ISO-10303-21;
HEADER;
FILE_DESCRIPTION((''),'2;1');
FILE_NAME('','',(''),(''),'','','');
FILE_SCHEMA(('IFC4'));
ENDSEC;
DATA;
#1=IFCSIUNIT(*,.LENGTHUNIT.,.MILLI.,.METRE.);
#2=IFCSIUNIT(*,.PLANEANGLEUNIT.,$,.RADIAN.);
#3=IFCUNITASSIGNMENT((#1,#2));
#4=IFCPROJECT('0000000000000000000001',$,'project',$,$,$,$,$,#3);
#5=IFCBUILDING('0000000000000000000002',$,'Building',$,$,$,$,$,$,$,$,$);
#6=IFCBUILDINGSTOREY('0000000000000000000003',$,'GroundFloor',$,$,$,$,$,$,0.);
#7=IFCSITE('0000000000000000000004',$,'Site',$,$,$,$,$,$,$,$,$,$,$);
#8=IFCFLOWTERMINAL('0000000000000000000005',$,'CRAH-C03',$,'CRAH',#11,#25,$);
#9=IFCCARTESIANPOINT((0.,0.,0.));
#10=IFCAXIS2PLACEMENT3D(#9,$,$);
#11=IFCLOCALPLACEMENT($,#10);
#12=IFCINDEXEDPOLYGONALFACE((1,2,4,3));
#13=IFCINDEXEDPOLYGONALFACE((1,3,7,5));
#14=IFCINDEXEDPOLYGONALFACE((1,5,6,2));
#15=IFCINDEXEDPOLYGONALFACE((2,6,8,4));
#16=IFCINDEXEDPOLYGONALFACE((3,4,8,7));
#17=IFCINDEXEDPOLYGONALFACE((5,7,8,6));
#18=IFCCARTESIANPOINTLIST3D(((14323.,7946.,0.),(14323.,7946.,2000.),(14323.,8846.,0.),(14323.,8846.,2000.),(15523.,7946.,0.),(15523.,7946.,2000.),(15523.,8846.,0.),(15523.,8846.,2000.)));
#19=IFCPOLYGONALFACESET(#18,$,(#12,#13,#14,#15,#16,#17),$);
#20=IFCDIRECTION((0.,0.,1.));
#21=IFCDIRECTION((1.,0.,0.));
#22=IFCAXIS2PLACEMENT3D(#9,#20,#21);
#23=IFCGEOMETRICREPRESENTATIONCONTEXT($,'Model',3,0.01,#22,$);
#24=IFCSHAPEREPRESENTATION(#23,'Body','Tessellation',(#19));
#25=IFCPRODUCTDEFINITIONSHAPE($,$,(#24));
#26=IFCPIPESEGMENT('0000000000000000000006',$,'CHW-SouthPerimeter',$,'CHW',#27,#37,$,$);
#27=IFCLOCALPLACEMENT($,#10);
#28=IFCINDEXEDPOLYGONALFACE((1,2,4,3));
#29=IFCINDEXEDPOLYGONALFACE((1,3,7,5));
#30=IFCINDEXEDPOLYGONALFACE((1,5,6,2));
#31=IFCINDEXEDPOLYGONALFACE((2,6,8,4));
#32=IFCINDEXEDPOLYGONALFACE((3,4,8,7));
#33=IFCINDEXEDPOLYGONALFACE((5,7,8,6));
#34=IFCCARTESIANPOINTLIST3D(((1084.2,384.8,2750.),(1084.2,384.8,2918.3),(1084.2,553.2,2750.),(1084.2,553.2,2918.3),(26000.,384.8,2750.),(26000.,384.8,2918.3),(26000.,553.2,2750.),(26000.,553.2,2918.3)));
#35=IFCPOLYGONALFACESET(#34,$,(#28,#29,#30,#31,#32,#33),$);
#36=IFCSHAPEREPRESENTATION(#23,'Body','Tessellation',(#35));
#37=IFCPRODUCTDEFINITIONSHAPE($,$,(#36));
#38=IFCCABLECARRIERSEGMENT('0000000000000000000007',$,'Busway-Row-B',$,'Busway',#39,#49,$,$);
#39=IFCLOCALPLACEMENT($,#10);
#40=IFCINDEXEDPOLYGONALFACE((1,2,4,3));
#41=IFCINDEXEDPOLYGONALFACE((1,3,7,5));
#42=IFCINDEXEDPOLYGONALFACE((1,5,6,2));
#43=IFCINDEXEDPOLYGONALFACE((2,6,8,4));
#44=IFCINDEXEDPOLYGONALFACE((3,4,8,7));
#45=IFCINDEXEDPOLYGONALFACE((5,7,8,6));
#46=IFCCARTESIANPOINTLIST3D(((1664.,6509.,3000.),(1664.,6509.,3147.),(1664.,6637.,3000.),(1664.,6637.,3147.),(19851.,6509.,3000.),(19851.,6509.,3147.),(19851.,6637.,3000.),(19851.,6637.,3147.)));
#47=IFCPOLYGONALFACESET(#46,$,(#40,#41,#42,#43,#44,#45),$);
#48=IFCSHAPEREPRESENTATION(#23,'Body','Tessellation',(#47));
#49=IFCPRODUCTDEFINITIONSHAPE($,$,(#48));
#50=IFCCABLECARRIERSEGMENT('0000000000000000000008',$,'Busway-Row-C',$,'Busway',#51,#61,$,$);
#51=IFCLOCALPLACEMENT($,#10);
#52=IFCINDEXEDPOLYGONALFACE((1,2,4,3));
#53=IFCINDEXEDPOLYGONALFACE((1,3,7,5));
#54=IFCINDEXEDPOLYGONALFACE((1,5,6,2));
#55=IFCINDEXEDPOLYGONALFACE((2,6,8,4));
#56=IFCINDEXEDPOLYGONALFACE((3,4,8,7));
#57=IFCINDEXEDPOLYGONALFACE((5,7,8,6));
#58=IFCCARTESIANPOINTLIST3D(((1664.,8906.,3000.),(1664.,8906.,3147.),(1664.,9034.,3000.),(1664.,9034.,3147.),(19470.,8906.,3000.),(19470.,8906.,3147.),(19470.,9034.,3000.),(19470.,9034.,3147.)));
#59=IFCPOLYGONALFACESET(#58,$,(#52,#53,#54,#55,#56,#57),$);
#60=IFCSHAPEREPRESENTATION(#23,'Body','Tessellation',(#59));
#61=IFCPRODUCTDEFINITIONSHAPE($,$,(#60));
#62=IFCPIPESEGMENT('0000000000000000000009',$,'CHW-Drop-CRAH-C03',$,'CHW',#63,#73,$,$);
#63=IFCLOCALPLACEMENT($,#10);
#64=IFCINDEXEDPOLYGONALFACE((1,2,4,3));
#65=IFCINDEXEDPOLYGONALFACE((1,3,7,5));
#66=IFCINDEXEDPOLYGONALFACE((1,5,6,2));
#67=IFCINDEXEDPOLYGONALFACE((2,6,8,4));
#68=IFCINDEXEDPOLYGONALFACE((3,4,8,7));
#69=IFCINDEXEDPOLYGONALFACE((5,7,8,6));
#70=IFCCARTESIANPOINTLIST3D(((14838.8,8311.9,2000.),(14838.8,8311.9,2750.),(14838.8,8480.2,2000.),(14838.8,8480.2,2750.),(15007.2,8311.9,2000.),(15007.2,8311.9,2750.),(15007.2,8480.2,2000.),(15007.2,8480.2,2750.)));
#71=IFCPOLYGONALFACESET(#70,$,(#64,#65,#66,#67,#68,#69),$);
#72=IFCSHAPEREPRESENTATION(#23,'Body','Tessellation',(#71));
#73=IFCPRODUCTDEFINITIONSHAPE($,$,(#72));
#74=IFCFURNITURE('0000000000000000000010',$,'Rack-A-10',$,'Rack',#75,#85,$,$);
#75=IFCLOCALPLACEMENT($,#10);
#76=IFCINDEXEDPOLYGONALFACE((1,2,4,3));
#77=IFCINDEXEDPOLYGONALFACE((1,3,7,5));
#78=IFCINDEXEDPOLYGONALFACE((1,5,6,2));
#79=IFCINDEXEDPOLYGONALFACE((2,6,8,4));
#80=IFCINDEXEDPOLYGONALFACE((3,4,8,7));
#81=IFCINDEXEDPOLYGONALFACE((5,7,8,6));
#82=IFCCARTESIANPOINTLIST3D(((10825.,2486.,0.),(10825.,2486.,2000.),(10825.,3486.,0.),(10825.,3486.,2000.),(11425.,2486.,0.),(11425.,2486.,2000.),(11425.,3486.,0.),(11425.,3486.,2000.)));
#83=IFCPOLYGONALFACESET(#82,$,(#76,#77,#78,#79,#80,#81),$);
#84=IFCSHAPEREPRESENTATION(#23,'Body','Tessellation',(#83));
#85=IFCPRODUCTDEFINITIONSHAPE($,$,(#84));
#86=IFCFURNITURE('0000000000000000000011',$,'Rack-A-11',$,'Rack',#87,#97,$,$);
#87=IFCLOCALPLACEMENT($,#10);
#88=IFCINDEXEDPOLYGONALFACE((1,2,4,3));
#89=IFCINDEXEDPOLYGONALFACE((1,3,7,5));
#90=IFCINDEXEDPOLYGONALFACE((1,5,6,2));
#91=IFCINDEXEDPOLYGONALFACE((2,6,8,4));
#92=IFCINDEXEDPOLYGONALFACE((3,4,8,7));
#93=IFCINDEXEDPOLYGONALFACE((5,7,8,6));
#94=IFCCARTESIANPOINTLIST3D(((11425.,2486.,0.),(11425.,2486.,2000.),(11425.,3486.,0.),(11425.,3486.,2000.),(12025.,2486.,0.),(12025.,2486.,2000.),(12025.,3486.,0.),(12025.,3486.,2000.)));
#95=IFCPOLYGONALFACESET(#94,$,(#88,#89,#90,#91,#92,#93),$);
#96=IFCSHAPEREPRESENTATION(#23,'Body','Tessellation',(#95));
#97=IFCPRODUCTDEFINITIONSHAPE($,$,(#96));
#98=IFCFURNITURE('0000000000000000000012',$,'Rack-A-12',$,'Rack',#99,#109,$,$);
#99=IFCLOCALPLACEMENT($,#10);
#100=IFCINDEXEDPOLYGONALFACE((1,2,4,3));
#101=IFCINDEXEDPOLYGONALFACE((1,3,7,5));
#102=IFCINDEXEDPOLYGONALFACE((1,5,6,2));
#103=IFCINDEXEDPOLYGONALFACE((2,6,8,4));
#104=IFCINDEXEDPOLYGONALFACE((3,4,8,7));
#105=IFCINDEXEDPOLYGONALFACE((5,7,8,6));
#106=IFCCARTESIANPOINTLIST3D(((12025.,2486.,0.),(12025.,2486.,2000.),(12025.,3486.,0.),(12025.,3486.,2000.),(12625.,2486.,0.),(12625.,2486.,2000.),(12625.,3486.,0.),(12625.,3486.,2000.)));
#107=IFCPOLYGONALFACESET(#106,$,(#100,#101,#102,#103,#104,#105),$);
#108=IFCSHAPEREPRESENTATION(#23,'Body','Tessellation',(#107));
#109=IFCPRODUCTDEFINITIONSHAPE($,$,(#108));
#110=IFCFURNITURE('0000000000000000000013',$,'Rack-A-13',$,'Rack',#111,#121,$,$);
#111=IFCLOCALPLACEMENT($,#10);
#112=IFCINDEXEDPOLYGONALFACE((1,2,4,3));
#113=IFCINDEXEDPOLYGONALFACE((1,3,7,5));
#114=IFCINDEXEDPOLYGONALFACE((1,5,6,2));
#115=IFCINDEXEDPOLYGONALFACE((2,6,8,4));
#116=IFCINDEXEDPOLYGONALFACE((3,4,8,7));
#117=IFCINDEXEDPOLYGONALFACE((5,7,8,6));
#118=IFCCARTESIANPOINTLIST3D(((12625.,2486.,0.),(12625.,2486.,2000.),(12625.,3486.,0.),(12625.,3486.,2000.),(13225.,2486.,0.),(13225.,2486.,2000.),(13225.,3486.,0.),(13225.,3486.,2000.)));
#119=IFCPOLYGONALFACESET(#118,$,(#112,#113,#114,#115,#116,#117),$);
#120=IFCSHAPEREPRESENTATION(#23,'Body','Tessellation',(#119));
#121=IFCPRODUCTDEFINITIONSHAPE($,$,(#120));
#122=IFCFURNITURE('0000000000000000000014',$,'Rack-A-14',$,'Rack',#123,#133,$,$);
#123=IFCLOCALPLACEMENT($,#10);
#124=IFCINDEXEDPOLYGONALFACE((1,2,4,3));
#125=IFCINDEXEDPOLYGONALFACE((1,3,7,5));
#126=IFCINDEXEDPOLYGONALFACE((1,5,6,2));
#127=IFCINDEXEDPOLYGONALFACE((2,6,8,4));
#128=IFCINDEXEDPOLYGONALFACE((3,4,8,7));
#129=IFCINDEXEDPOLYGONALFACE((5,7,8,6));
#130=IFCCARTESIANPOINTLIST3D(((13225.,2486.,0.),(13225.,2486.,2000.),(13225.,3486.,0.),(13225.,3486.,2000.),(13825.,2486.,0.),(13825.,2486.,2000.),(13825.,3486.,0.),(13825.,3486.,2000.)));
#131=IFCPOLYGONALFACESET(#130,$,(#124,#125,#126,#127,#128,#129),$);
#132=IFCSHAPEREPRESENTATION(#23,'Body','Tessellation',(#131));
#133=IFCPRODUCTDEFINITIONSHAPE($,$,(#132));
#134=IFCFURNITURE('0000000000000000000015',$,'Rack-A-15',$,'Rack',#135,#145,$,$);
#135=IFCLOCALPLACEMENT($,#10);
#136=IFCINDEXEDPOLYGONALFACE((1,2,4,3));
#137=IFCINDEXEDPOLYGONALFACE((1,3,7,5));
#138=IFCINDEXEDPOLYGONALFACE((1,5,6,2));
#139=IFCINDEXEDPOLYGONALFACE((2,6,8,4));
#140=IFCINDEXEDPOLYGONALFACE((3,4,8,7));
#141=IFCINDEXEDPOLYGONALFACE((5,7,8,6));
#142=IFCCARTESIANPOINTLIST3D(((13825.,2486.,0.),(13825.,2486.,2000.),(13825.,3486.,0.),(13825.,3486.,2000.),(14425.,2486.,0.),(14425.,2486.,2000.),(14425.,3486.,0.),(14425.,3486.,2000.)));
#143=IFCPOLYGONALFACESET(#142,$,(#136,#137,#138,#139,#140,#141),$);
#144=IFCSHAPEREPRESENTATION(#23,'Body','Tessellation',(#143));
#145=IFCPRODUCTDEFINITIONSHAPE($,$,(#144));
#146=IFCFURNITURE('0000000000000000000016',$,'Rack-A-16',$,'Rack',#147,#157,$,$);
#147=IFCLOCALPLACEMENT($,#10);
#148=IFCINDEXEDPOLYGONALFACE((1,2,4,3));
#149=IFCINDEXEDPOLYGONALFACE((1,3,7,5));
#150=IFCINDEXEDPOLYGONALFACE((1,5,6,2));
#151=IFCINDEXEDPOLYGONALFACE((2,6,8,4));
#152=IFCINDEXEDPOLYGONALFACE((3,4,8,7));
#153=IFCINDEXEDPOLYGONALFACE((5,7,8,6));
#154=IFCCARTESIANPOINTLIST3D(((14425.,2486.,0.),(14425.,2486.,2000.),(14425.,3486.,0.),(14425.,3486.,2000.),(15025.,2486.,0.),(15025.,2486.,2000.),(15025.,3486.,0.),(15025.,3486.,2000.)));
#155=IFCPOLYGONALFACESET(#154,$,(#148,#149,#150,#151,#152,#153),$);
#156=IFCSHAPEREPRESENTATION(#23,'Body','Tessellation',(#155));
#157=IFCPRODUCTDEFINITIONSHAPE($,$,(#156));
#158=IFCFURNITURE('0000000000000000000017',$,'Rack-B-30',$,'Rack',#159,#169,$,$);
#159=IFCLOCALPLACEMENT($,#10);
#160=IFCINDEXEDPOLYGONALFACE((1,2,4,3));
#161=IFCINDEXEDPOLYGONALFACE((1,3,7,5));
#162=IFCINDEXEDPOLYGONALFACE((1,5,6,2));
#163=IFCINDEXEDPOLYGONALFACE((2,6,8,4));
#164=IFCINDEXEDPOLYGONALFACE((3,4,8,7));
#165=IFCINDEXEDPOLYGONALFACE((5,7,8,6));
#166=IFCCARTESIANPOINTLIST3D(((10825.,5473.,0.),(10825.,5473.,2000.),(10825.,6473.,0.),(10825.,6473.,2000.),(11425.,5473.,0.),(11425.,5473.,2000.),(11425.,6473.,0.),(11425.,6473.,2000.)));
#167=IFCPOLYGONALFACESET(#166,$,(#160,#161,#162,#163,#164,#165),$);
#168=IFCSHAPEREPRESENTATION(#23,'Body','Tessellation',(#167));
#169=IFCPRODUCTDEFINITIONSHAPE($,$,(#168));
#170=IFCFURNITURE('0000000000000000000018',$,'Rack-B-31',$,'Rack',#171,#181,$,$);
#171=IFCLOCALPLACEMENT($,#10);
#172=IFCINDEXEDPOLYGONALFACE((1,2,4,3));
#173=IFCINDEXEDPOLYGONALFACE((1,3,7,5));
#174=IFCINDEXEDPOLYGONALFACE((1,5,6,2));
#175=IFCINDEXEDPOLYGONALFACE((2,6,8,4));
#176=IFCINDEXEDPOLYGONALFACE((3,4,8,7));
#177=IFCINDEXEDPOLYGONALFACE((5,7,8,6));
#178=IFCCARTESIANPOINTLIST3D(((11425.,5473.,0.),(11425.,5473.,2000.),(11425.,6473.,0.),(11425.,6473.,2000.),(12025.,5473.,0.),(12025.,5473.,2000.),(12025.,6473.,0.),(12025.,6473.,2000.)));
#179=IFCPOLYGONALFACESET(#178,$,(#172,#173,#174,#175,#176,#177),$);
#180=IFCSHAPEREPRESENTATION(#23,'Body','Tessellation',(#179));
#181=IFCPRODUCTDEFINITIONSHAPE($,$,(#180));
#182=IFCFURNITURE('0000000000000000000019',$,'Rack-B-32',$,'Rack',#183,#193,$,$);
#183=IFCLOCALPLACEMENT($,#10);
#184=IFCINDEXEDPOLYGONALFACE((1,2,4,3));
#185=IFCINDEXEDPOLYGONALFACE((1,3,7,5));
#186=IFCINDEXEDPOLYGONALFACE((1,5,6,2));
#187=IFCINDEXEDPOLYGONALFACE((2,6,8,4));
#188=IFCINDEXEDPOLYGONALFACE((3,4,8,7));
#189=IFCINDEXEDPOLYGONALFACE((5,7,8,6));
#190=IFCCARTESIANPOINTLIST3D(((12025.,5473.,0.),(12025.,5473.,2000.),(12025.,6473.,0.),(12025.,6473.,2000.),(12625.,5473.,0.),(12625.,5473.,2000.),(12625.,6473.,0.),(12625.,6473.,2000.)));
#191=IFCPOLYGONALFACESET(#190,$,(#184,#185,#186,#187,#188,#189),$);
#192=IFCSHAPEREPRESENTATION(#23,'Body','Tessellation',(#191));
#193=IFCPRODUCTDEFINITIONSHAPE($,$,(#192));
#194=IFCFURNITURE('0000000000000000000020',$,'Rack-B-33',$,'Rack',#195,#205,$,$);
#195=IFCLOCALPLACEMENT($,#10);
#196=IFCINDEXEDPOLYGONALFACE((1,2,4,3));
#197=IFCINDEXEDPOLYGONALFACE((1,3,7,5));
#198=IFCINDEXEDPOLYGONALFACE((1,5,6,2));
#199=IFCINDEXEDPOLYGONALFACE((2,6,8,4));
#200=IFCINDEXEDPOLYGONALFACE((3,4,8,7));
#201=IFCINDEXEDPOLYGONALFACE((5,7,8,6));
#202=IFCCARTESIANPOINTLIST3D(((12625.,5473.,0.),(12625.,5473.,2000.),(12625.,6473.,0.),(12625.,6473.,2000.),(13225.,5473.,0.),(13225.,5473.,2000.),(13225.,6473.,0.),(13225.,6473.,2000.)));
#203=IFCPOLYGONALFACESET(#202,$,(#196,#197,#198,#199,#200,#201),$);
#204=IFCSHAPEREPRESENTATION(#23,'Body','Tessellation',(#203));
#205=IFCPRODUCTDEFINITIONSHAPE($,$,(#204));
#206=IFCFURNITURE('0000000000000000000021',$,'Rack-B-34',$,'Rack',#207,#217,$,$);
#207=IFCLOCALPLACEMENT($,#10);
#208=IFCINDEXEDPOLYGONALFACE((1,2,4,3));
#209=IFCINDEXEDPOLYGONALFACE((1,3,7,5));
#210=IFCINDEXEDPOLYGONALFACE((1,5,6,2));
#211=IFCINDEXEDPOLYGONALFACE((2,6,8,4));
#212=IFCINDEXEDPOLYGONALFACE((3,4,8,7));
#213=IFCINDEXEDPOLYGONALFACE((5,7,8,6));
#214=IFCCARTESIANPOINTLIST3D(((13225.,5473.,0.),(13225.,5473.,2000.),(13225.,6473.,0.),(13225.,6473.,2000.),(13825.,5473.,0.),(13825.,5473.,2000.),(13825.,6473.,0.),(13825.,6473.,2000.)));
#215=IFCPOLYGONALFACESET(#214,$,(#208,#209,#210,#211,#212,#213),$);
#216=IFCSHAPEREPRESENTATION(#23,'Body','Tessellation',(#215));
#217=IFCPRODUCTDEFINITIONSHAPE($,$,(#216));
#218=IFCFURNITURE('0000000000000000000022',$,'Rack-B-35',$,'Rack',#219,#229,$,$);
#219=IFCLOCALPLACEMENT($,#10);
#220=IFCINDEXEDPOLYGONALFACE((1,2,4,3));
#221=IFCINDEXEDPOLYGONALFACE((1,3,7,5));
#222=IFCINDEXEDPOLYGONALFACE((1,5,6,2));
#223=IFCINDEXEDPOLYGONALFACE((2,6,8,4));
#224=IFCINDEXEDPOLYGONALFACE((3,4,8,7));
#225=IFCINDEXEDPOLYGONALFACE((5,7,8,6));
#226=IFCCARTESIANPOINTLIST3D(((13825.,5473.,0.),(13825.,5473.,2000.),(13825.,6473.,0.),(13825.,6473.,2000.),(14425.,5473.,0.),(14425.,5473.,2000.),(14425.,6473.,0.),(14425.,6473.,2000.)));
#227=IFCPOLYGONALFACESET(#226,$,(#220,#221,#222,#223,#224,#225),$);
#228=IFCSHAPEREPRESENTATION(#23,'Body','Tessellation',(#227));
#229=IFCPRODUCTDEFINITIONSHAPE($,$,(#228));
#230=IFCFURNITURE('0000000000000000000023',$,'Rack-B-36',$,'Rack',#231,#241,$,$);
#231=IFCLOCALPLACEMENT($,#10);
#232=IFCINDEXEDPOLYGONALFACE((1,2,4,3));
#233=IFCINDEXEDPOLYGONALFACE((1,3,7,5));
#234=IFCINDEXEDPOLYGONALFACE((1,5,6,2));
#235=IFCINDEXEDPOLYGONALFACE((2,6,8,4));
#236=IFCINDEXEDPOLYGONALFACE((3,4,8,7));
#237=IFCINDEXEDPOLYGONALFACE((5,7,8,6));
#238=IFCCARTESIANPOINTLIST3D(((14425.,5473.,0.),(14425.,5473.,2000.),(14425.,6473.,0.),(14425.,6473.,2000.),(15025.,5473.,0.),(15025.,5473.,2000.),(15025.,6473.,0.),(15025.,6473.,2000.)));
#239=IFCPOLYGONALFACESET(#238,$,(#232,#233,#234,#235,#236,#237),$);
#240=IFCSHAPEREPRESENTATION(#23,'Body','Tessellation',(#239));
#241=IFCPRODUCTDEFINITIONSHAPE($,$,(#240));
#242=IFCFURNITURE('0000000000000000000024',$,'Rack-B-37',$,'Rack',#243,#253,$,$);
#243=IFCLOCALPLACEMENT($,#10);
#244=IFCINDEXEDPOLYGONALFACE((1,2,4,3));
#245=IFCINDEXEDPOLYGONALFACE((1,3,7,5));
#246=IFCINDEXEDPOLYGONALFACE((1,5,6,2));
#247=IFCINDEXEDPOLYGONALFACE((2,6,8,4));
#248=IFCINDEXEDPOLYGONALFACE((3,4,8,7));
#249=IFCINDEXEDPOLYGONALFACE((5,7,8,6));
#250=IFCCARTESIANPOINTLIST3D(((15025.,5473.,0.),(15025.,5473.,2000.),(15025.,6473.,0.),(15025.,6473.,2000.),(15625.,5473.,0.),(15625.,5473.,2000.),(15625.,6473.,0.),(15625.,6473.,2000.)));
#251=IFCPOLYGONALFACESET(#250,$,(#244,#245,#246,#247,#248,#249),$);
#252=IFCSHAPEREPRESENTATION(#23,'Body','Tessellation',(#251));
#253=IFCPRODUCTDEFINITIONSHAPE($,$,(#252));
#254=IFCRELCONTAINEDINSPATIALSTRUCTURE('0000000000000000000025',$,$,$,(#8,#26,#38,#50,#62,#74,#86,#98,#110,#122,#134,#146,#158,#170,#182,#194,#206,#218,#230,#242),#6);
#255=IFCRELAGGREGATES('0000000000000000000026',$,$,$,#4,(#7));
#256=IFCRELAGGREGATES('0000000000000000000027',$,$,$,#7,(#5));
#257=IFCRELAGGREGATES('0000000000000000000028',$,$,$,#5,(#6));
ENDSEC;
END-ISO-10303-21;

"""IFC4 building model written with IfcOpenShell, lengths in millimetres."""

from ifc_helpers import new_model, si_unit, frame, origin, origin_with_axes, origin_2d, place, context, project, spatial, rectangle, extrude, element, save


model = new_model("IFC4")

# Units and contexts
model_context = context("Model", 3, precision=0.01, world=origin_with_axes())
ifc_project = project(units=[si_unit("LENGTHUNIT", "METRE", prefix="MILLI"), si_unit("PLANEANGLEUNIT", "RADIAN")])

# Site, building, storey
site = spatial("IfcSite", under=ifc_project, Name="Site")
building = spatial("IfcBuilding", under=site, Name="Building")
storey = spatial("IfcBuildingStorey", under=building, Name="GroundFloor", Elevation=0.0)

# Flow terminal
flow_terminal_placement = place(None, frame((14923.0, 8396.0, 0.0), z_axis=(0.0, 0.0, 1.0), x_axis=(1.0, 0.0, 0.0)))
element("IfcFlowTerminal", 1, at=flow_terminal_placement, inside=storey, Name="CRAH-C03", ObjectType="CRAH", context=model_context, shape_type="SweptSolid", body=[
    extrude(rectangle(XDim=1200.0, YDim=900.0, at=origin_2d()), origin(), (0.0, 0.0, 1.0), 2000.0),
])

# Pipe segment
pipe_segment_1_placement = place(None, frame((13542.1, 469.0, 2750.0), z_axis=(0.0, 0.0, 1.0), x_axis=(1.0, 0.0, 0.0)))
element("IfcPipeSegment", 2, at=pipe_segment_1_placement, inside=storey, Name="CHW-SouthPerimeter", ObjectType="CHW", context=model_context, shape_type="SweptSolid", body=[
    extrude(rectangle(XDim=24915.8, YDim=168.3, at=origin_2d()), origin(), (0.0, 0.0, 1.0), 168.3),
])

# Cable carrier segments
cable_carrier_segment_1_placement = place(None, frame((10757.5, 6573.0, 3000.0), z_axis=(0.0, 0.0, 1.0), x_axis=(1.0, 0.0, 0.0)))
element("IfcCableCarrierSegment", 3, at=cable_carrier_segment_1_placement, inside=storey, Name="Busway-Row-B", ObjectType="Busway", context=model_context, shape_type="SweptSolid", body=[
    extrude(rectangle(XDim=18187.0, YDim=128.0, at=origin_2d()), origin(), (0.0, 0.0, 1.0), 147.0),
])
cable_carrier_segment_2_placement = place(None, frame((10567.0, 8970.0, 3000.0), z_axis=(0.0, 0.0, 1.0), x_axis=(1.0, 0.0, 0.0)))
element("IfcCableCarrierSegment", 4, at=cable_carrier_segment_2_placement, inside=storey, Name="Busway-Row-C", ObjectType="Busway", context=model_context, shape_type="SweptSolid", body=[
    extrude(rectangle(XDim=17806.0, YDim=128.0, at=origin_2d()), origin(), (0.0, 0.0, 1.0), 147.0),
])

# Pipe segment
pipe_segment_2_placement = place(None, frame((14923.0, 8396.0, 2000.0), z_axis=(0.0, 0.0, 1.0), x_axis=(1.0, 0.0, 0.0)))
element("IfcPipeSegment", 5, at=pipe_segment_2_placement, inside=storey, Name="CHW-Drop-CRAH-C03", ObjectType="CHW", context=model_context, shape_type="SweptSolid", body=[
    extrude(rectangle(XDim=168.3, YDim=168.3, at=origin_2d()), origin(), (0.0, 0.0, 1.0), 750.0),
])

# Furniture
for number, where, z_axis, x_axis, name in (
    (6, (11125.0, 2986.0, 0.0), (0.0, 0.0, 1.0), (1.0, 0.0, 0.0), "Rack-A-10"),
    (7, (11725.0, 2986.0, 0.0), (0.0, 0.0, 1.0), (1.0, 0.0, 0.0), "Rack-A-11"),
    (8, (12325.0, 2986.0, 0.0), (0.0, 0.0, 1.0), (1.0, 0.0, 0.0), "Rack-A-12"),
    (9, (12925.0, 2986.0, 0.0), (0.0, 0.0, 1.0), (1.0, 0.0, 0.0), "Rack-A-13"),
    (10, (13525.0, 2986.0, 0.0), (0.0, 0.0, 1.0), (1.0, 0.0, 0.0), "Rack-A-14"),
    (11, (14125.0, 2986.0, 0.0), (0.0, 0.0, 1.0), (1.0, 0.0, 0.0), "Rack-A-15"),
    (12, (14725.0, 2986.0, 0.0), (0.0, 0.0, 1.0), (1.0, 0.0, 0.0), "Rack-A-16"),
    (13, (11125.0, 5973.0, 0.0), (0.0, 0.0, 1.0), (1.0, 0.0, 0.0), "Rack-B-30"),
    (14, (11725.0, 5973.0, 0.0), (0.0, 0.0, 1.0), (1.0, 0.0, 0.0), "Rack-B-31"),
    (15, (12325.0, 5973.0, 0.0), (0.0, 0.0, 1.0), (1.0, 0.0, 0.0), "Rack-B-32"),
    (16, (12925.0, 5973.0, 0.0), (0.0, 0.0, 1.0), (1.0, 0.0, 0.0), "Rack-B-33"),
    (17, (13525.0, 5973.0, 0.0), (0.0, 0.0, 1.0), (1.0, 0.0, 0.0), "Rack-B-34"),
    (18, (14125.0, 5973.0, 0.0), (0.0, 0.0, 1.0), (1.0, 0.0, 0.0), "Rack-B-35"),
    (19, (14725.0, 5973.0, 0.0), (0.0, 0.0, 1.0), (1.0, 0.0, 0.0), "Rack-B-36"),
    (20, (15325.0, 5973.0, 0.0), (0.0, 0.0, 1.0), (1.0, 0.0, 0.0), "Rack-B-37"),
):
    element("IfcFurniture", number, at=place(None, frame(where, z_axis=z_axis, x_axis=x_axis)), inside=storey, Name=name, ObjectType="Rack", context=model_context, shape_type="SweptSolid", body=[
        extrude(rectangle(XDim=600.0, YDim=1000.0, at=origin_2d()), origin(), (0.0, 0.0, 1.0), 2000.0),
    ])

save(model, "model.ifc")
